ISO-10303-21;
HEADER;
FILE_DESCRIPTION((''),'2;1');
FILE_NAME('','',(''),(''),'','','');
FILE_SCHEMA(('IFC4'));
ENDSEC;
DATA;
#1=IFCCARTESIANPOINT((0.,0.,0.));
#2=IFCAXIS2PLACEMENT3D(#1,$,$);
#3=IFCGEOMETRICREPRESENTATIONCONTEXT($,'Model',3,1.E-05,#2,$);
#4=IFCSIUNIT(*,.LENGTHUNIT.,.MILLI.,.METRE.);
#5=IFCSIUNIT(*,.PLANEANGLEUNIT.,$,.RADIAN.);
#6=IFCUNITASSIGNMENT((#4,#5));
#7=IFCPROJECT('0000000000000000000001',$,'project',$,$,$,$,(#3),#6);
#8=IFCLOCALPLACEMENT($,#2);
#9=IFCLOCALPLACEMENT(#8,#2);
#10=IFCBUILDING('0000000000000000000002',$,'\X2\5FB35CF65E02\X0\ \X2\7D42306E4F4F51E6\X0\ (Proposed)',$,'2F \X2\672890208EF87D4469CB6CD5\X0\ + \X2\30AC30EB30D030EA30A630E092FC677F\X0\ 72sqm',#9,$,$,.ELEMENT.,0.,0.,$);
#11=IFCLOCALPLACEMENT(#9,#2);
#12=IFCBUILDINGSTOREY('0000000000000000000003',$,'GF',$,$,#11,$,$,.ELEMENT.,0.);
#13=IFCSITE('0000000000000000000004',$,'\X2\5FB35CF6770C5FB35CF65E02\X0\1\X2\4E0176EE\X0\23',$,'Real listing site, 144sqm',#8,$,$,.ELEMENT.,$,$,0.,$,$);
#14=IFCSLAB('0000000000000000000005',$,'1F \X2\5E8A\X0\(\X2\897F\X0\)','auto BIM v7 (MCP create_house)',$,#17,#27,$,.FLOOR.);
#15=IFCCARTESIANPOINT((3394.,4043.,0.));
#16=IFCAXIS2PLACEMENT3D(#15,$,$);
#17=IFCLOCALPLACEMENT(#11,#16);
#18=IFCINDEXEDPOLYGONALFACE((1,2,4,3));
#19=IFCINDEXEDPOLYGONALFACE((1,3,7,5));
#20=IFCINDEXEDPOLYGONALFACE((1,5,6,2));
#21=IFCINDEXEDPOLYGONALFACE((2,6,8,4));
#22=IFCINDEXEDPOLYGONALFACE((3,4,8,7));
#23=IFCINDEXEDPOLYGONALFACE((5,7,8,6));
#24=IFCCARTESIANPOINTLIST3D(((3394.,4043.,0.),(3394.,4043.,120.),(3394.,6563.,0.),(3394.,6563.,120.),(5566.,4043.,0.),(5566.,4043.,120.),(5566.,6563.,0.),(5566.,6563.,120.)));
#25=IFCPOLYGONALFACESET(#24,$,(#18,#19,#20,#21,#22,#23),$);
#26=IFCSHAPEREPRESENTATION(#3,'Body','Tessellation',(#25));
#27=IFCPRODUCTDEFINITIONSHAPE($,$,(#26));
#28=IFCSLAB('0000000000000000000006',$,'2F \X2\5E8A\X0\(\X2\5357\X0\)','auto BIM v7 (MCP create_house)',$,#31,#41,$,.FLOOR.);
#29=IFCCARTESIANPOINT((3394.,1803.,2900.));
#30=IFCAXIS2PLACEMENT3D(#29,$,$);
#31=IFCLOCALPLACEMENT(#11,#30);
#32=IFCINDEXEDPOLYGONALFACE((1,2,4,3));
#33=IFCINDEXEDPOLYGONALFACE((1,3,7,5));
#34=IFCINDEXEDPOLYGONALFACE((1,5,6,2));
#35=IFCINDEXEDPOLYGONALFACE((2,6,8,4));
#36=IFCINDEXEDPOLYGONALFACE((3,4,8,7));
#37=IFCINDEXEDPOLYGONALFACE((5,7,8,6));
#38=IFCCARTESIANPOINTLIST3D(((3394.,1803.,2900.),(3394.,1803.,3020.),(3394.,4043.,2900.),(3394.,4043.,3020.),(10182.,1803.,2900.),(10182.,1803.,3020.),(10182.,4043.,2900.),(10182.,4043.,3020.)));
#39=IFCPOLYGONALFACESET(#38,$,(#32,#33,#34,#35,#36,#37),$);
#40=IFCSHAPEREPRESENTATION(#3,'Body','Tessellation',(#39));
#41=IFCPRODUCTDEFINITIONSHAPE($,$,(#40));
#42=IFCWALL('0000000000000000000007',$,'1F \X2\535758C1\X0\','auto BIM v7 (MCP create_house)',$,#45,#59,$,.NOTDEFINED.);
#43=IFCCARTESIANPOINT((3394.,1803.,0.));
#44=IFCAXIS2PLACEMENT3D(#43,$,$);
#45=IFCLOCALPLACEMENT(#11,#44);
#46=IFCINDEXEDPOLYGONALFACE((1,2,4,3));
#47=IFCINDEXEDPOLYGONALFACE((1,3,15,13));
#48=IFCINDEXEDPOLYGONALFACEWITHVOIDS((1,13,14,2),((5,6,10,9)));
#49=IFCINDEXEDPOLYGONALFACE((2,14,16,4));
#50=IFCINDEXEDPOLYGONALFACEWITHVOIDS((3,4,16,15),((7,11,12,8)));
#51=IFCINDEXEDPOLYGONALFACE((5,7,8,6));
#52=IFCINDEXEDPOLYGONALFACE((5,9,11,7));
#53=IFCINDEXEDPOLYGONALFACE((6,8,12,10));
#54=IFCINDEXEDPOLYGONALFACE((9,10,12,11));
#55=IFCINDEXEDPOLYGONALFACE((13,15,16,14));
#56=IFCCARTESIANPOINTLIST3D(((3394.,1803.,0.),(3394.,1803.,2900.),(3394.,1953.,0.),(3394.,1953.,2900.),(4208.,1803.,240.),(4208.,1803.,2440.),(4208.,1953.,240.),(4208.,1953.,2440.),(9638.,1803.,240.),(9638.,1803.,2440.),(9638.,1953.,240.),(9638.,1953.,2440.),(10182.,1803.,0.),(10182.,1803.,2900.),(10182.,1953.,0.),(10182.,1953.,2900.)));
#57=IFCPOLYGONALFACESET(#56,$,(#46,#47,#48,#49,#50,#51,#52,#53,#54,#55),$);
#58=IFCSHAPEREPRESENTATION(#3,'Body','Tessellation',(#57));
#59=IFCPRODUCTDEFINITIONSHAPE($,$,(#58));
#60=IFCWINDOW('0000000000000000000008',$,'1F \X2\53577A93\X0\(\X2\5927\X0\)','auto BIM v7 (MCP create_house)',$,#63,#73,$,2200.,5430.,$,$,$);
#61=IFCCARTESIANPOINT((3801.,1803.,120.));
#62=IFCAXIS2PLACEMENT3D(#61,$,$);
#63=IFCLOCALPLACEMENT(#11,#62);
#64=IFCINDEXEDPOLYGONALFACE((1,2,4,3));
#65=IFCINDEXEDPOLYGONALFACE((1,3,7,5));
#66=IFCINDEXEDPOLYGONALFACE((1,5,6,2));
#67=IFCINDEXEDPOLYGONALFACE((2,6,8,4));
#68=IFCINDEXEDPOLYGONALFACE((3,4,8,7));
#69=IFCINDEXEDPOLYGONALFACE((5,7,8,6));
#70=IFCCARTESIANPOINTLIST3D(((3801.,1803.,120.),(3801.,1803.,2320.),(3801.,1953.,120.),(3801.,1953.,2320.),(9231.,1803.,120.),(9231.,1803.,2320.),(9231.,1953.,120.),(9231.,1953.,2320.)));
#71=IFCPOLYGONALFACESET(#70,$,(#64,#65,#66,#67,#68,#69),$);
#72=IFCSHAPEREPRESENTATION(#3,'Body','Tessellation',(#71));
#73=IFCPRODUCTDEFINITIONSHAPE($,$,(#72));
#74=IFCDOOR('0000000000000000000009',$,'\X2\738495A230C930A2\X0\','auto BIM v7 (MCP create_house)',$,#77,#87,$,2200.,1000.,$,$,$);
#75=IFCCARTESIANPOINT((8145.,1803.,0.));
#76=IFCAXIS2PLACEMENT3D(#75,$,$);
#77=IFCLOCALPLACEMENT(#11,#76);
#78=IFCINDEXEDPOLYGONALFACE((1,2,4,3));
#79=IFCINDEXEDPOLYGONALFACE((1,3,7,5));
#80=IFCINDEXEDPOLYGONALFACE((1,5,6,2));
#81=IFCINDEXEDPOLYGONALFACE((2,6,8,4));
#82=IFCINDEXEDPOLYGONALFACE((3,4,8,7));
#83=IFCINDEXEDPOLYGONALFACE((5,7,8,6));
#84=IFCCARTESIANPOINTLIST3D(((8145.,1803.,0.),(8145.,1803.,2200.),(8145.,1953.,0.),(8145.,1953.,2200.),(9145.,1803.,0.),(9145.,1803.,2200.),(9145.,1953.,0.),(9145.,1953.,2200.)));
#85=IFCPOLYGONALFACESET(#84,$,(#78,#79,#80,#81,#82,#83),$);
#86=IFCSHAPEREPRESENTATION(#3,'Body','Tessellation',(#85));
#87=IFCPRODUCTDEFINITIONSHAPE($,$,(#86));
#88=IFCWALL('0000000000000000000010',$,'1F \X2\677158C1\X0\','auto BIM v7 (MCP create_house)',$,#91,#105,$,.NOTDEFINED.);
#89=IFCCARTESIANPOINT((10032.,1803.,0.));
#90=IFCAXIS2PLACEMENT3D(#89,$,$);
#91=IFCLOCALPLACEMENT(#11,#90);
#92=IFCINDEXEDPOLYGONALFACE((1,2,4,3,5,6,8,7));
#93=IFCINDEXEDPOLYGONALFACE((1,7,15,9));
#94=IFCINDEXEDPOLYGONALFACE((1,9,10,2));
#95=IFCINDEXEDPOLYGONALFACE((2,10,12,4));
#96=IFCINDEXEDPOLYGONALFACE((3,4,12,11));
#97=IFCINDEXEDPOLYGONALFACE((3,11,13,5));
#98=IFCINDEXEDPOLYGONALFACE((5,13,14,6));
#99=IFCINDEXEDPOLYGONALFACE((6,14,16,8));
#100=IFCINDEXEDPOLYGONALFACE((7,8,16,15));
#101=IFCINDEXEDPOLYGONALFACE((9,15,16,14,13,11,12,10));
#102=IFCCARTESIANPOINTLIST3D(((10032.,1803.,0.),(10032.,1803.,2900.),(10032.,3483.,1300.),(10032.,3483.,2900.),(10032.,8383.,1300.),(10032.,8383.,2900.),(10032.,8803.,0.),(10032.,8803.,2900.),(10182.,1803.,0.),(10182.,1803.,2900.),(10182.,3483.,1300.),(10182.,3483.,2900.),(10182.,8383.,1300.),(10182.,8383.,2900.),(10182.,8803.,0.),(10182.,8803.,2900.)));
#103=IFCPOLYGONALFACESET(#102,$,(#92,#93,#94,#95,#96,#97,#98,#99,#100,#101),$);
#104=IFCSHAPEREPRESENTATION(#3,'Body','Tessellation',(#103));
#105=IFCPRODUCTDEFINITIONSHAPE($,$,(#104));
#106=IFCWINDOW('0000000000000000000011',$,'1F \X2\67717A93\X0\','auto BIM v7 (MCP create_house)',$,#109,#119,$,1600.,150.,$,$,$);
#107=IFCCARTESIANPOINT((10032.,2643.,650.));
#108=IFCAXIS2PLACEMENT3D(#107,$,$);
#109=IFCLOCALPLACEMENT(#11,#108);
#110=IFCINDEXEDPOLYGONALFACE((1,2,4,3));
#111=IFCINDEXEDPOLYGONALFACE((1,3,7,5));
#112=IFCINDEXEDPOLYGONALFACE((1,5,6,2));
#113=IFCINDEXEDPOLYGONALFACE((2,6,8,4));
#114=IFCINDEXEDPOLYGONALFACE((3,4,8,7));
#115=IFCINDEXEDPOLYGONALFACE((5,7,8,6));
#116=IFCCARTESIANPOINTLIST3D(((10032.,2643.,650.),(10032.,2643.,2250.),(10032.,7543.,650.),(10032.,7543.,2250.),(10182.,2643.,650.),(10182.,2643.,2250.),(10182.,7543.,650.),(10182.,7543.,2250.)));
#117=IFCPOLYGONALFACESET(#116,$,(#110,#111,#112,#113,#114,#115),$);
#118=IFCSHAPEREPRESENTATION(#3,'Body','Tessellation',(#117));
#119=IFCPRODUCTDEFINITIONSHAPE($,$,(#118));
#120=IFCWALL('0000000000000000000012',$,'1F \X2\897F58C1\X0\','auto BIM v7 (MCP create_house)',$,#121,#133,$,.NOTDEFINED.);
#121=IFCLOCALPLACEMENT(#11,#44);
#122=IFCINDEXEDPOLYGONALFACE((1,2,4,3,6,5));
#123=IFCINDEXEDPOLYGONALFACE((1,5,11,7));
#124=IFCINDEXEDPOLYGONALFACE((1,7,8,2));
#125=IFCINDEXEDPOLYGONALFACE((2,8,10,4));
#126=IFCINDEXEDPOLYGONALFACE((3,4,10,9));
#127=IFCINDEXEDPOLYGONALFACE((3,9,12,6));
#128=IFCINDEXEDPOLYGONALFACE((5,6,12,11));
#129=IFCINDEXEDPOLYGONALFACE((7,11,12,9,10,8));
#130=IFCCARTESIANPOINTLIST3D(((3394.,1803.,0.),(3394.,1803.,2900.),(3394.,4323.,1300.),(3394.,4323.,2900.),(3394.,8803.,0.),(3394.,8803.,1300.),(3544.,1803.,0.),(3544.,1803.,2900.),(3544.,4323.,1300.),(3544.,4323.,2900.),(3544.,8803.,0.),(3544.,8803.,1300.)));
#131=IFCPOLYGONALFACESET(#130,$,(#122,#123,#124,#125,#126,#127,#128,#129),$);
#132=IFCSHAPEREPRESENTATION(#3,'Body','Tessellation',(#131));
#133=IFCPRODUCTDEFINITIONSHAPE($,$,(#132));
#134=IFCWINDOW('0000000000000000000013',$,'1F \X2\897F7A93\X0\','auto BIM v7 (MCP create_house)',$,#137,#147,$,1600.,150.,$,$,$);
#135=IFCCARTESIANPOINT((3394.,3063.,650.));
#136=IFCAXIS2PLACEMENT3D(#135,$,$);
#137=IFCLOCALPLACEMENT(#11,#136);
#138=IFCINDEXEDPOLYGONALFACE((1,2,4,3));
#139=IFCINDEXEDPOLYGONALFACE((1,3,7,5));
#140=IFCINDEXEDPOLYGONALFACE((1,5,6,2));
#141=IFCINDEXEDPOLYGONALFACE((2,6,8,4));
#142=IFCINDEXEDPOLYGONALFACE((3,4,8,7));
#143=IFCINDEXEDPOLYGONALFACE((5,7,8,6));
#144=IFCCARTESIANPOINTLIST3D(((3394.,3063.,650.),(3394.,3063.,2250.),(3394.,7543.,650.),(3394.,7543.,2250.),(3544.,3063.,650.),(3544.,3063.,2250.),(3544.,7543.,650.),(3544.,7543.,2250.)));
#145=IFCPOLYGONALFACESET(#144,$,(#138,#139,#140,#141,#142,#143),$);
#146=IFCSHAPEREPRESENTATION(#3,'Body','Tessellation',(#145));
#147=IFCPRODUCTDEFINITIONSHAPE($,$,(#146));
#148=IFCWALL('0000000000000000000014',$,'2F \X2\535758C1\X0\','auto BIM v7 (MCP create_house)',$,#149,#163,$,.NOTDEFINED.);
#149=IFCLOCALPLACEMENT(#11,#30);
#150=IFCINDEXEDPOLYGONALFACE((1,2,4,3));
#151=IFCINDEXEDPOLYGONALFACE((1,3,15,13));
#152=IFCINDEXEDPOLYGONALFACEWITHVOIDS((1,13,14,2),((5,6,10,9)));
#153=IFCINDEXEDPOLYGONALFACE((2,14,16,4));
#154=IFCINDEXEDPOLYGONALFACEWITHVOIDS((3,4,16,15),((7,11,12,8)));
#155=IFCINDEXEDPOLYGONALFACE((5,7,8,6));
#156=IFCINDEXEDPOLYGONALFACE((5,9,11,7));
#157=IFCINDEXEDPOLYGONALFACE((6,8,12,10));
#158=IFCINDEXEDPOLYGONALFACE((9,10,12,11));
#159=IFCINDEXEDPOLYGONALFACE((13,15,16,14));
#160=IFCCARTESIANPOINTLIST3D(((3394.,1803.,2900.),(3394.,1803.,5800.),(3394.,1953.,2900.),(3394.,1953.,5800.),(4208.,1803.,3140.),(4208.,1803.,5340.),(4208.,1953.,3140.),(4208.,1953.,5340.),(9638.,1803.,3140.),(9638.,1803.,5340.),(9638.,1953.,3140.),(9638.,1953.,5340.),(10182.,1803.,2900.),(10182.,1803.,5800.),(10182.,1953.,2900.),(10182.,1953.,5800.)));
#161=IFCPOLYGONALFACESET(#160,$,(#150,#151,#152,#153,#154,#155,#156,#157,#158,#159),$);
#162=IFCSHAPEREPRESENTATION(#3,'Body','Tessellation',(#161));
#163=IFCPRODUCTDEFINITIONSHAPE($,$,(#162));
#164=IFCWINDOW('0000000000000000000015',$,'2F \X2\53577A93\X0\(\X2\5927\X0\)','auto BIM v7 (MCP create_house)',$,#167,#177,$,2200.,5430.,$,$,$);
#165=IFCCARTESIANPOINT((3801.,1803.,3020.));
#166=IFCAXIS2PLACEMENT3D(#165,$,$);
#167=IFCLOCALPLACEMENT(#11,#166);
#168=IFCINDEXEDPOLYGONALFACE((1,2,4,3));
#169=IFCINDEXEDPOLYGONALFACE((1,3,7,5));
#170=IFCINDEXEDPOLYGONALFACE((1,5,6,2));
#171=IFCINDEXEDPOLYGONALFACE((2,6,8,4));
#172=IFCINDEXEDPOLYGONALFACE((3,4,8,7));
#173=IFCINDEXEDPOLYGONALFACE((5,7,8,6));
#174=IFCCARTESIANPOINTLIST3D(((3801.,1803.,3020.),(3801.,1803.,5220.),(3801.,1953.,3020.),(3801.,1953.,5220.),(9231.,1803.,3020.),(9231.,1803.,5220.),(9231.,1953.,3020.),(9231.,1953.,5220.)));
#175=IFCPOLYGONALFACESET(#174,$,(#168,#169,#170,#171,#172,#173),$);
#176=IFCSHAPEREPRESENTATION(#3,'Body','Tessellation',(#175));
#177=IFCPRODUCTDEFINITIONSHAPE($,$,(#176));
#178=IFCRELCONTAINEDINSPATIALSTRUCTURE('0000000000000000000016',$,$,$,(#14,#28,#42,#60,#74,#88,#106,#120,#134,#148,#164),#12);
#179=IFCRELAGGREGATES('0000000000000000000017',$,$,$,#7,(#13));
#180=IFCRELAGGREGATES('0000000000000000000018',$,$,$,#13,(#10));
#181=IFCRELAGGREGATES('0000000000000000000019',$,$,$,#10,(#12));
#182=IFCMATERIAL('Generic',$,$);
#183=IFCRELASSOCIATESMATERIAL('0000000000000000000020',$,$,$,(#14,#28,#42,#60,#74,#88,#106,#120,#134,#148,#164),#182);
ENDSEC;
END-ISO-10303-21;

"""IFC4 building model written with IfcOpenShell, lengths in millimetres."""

from ifc_helpers import new_model, si_unit, frame, frame_2d, origin, place, context, project, spatial, rectangle, extrude, material, element, fill, save


model = new_model("IFC4")

# Units and contexts
model_context = context("Model", 3, precision=1e-05, world=origin())
ifc_project = project(units=[si_unit("LENGTHUNIT", "METRE", prefix="MILLI"), si_unit("PLANEANGLEUNIT", "RADIAN")], contexts=[model_context])

# Site, building, storey
site_placement = place(None, origin())
site = spatial("IfcSite", under=ifc_project, at=site_placement, Name="徳島県徳島市1丁目23", ObjectType="Real listing site, 144sqm", CompositionType="ELEMENT", RefElevation=0.0)
building_placement = place(site_placement, origin())
building = spatial("IfcBuilding", under=site, at=building_placement, Name="徳島市 終の住処 (Proposed)", ObjectType="2F 木造軸組構法 + ガルバリウム鋼板 72sqm", CompositionType="ELEMENT", ElevationOfRefHeight=0.0, ElevationOfTerrain=0.0)
storey_placement = place(building_placement, origin())
storey = spatial("IfcBuildingStorey", under=building, at=storey_placement, Name="GF", CompositionType="ELEMENT", Elevation=0.0)

# Slabs
ifc_material = material(Name="Generic")
slab_1_placement = place(storey_placement, frame((3394.0, 4043.0, 0.0)))
element("IfcSlab", 1, at=slab_1_placement, inside=storey, material=ifc_material, Name="1F 床(西)", Description="auto BIM v7 (MCP create_house)", PredefinedType="FLOOR", context=model_context, shape_type="SweptSolid", body=[
    extrude(rectangle(XDim=2172.0, YDim=2520.0, at=frame_2d((1086.0, 1260.0))), frame((3394.0, 4043.0, 0.0)), (0.0, 0.0, 1.0), 120.0),
])
slab_2_placement = place(storey_placement, frame((3394.0, 1803.0, 2900.0)))
element("IfcSlab", 2, at=slab_2_placement, inside=storey, material=ifc_material, Name="2F 床(南)", Description="auto BIM v7 (MCP create_house)", PredefinedType="FLOOR", context=model_context, shape_type="SweptSolid", body=[
    extrude(rectangle(XDim=6788.0, YDim=2240.0, at=frame_2d((3394.0, 1120.0))), frame((3394.0, 1803.0, 2900.0)), (0.0, 0.0, 1.0), 120.0),
])

# Wall, openings, window, door
wall_1_placement = place(storey_placement, frame((3394.0, 1803.0, 0.0)))
wall_1 = element("IfcWall", 3, at=wall_1_placement, inside=storey, material=ifc_material, Name="1F 南壁", Description="auto BIM v7 (MCP create_house)", PredefinedType="NOTDEFINED", context=model_context, shape_type="SweptSolid", body=[
    extrude(rectangle(XDim=6788.0, YDim=150.0, at=frame_2d((3394.0, 75.0))), frame((3394.0, 1803.0, 0.0)), (0.0, 0.0, 1.0), 2900.0),
])
opening_1_placement = place(storey_placement, frame((3801.0, 1803.0, 120.0)))
opening_1 = element("IfcOpeningElement", 4, at=opening_1_placement, cuts=wall_1, PredefinedType="NOTDEFINED", context=model_context, shape_type="SweptSolid", body=[
    extrude(rectangle(XDim=5430.0, YDim=150.0, at=frame_2d((2715.0, 75.0))), frame((3801.0, 1803.0, 120.0)), (0.0, 0.0, 1.0), 2200.0),
])
opening_2_placement = place(storey_placement, frame((8145.0, 1803.0, 0.0)))
opening_2 = element("IfcOpeningElement", 5, at=opening_2_placement, cuts=wall_1, PredefinedType="NOTDEFINED", context=model_context, shape_type="SweptSolid", body=[
    extrude(rectangle(XDim=1000.0, YDim=150.0, at=frame_2d((500.0, 75.0))), frame((8145.0, 1803.0, 0.0)), (0.0, 0.0, 1.0), 2200.0),
])
window_1_placement = place(storey_placement, frame((3801.0, 1803.0, 120.0)))
window_1 = element("IfcWindow", 6, at=window_1_placement, inside=storey, material=ifc_material, Name="1F 南窓(大)", Description="auto BIM v7 (MCP create_house)", OverallHeight=2200.0, OverallWidth=5430.0, context=model_context, shape_type="SweptSolid", body=[
    extrude(rectangle(XDim=5430.0, YDim=150.0, at=frame_2d((2715.0, 75.0))), frame((3801.0, 1803.0, 120.0)), (0.0, 0.0, 1.0), 2200.0),
])
fill(opening_1, window_1)
door_placement = place(storey_placement, frame((8145.0, 1803.0, 0.0)))
door = element("IfcDoor", 7, at=door_placement, inside=storey, material=ifc_material, Name="玄関ドア", Description="auto BIM v7 (MCP create_house)", OverallHeight=2200.0, OverallWidth=1000.0, context=model_context, shape_type="SweptSolid", body=[
    extrude(rectangle(XDim=1000.0, YDim=150.0, at=frame_2d((500.0, 75.0))), frame((8145.0, 1803.0, 0.0)), (0.0, 0.0, 1.0), 2200.0),
])
fill(opening_2, door)

# Walls, openings, windows
wall_2_placement = place(storey_placement, frame((10032.0, 1803.0, 0.0)))
wall_2 = element("IfcWall", 8, at=wall_2_placement, inside=storey, material=ifc_material, Name="1F 東壁", Description="auto BIM v7 (MCP create_house)", PredefinedType="NOTDEFINED", context=model_context, shape_type="SweptSolid", body=[
    extrude(rectangle(XDim=150.0, YDim=7000.0, at=frame_2d((75.0, 3500.0))), frame((10032.0, 1803.0, 0.0)), (0.0, 0.0, 1.0), 2900.0),
])
opening_3_placement = place(storey_placement, frame((10032.0, 2643.0, 650.0)))
opening_3 = element("IfcOpeningElement", 9, at=opening_3_placement, cuts=wall_2, PredefinedType="NOTDEFINED", context=model_context, shape_type="SweptSolid", body=[
    extrude(rectangle(XDim=150.0, YDim=4900.0, at=frame_2d((75.0, 2450.0))), frame((10032.0, 2643.0, 650.0)), (0.0, 0.0, 1.0), 1600.0),
])
window_2_placement = place(storey_placement, frame((10032.0, 2643.0, 650.0)))
window_2 = element("IfcWindow", 10, at=window_2_placement, inside=storey, material=ifc_material, Name="1F 東窓", Description="auto BIM v7 (MCP create_house)", OverallHeight=1600.0, OverallWidth=150.0, context=model_context, shape_type="SweptSolid", body=[
    extrude(rectangle(XDim=150.0, YDim=4900.0, at=frame_2d((75.0, 2450.0))), frame((10032.0, 2643.0, 650.0)), (0.0, 0.0, 1.0), 1600.0),
])
fill(opening_3, window_2)
wall_3_placement = place(storey_placement, frame((3394.0, 1803.0, 0.0)))
wall_3 = element("IfcWall", 11, at=wall_3_placement, inside=storey, material=ifc_material, Name="1F 西壁", Description="auto BIM v7 (MCP create_house)", PredefinedType="NOTDEFINED", context=model_context, shape_type="SweptSolid", body=[
    extrude(rectangle(XDim=150.0, YDim=7000.0, at=frame_2d((75.0, 3500.0))), frame((3394.0, 1803.0, 0.0)), (0.0, 0.0, 1.0), 2900.0),
])
opening_4_placement = place(storey_placement, frame((3394.0, 3063.0, 650.0)))
opening_4 = element("IfcOpeningElement", 12, at=opening_4_placement, cuts=wall_3, PredefinedType="NOTDEFINED", context=model_context, shape_type="SweptSolid", body=[
    extrude(rectangle(XDim=150.0, YDim=4480.0, at=frame_2d((75.0, 2240.0))), frame((3394.0, 3063.0, 650.0)), (0.0, 0.0, 1.0), 1600.0),
])
window_3_placement = place(storey_placement, frame((3394.0, 3063.0, 650.0)))
window_3 = element("IfcWindow", 13, at=window_3_placement, inside=storey, material=ifc_material, Name="1F 西窓", Description="auto BIM v7 (MCP create_house)", OverallHeight=1600.0, OverallWidth=150.0, context=model_context, shape_type="SweptSolid", body=[
    extrude(rectangle(XDim=150.0, YDim=4480.0, at=frame_2d((75.0, 2240.0))), frame((3394.0, 3063.0, 650.0)), (0.0, 0.0, 1.0), 1600.0),
])
fill(opening_4, window_3)

# Wall, opening, window
wall_4_placement = place(storey_placement, frame((3394.0, 1803.0, 2900.0)))
wall_4 = element("IfcWall", 14, at=wall_4_placement, inside=storey, material=ifc_material, Name="2F 南壁", Description="auto BIM v7 (MCP create_house)", PredefinedType="NOTDEFINED", context=model_context, shape_type="SweptSolid", body=[
    extrude(rectangle(XDim=6788.0, YDim=150.0, at=frame_2d((3394.0, 75.0))), frame((3394.0, 1803.0, 2900.0)), (0.0, 0.0, 1.0), 2900.0),
])
opening_5_placement = place(storey_placement, frame((3801.0, 1803.0, 3020.0)))
opening_5 = element("IfcOpeningElement", 15, at=opening_5_placement, cuts=wall_4, PredefinedType="NOTDEFINED", context=model_context, shape_type="SweptSolid", body=[
    extrude(rectangle(XDim=5430.0, YDim=150.0, at=frame_2d((2715.0, 75.0))), frame((3801.0, 1803.0, 3020.0)), (0.0, 0.0, 1.0), 2200.0),
])
window_4_placement = place(storey_placement, frame((3801.0, 1803.0, 3020.0)))
window_4 = element("IfcWindow", 16, at=window_4_placement, inside=storey, material=ifc_material, Name="2F 南窓(大)", Description="auto BIM v7 (MCP create_house)", OverallHeight=2200.0, OverallWidth=5430.0, context=model_context, shape_type="SweptSolid", body=[
    extrude(rectangle(XDim=5430.0, YDim=150.0, at=frame_2d((2715.0, 75.0))), frame((3801.0, 1803.0, 3020.0)), (0.0, 0.0, 1.0), 2200.0),
])
fill(opening_5, window_4)

save(model, "model.ifc")
